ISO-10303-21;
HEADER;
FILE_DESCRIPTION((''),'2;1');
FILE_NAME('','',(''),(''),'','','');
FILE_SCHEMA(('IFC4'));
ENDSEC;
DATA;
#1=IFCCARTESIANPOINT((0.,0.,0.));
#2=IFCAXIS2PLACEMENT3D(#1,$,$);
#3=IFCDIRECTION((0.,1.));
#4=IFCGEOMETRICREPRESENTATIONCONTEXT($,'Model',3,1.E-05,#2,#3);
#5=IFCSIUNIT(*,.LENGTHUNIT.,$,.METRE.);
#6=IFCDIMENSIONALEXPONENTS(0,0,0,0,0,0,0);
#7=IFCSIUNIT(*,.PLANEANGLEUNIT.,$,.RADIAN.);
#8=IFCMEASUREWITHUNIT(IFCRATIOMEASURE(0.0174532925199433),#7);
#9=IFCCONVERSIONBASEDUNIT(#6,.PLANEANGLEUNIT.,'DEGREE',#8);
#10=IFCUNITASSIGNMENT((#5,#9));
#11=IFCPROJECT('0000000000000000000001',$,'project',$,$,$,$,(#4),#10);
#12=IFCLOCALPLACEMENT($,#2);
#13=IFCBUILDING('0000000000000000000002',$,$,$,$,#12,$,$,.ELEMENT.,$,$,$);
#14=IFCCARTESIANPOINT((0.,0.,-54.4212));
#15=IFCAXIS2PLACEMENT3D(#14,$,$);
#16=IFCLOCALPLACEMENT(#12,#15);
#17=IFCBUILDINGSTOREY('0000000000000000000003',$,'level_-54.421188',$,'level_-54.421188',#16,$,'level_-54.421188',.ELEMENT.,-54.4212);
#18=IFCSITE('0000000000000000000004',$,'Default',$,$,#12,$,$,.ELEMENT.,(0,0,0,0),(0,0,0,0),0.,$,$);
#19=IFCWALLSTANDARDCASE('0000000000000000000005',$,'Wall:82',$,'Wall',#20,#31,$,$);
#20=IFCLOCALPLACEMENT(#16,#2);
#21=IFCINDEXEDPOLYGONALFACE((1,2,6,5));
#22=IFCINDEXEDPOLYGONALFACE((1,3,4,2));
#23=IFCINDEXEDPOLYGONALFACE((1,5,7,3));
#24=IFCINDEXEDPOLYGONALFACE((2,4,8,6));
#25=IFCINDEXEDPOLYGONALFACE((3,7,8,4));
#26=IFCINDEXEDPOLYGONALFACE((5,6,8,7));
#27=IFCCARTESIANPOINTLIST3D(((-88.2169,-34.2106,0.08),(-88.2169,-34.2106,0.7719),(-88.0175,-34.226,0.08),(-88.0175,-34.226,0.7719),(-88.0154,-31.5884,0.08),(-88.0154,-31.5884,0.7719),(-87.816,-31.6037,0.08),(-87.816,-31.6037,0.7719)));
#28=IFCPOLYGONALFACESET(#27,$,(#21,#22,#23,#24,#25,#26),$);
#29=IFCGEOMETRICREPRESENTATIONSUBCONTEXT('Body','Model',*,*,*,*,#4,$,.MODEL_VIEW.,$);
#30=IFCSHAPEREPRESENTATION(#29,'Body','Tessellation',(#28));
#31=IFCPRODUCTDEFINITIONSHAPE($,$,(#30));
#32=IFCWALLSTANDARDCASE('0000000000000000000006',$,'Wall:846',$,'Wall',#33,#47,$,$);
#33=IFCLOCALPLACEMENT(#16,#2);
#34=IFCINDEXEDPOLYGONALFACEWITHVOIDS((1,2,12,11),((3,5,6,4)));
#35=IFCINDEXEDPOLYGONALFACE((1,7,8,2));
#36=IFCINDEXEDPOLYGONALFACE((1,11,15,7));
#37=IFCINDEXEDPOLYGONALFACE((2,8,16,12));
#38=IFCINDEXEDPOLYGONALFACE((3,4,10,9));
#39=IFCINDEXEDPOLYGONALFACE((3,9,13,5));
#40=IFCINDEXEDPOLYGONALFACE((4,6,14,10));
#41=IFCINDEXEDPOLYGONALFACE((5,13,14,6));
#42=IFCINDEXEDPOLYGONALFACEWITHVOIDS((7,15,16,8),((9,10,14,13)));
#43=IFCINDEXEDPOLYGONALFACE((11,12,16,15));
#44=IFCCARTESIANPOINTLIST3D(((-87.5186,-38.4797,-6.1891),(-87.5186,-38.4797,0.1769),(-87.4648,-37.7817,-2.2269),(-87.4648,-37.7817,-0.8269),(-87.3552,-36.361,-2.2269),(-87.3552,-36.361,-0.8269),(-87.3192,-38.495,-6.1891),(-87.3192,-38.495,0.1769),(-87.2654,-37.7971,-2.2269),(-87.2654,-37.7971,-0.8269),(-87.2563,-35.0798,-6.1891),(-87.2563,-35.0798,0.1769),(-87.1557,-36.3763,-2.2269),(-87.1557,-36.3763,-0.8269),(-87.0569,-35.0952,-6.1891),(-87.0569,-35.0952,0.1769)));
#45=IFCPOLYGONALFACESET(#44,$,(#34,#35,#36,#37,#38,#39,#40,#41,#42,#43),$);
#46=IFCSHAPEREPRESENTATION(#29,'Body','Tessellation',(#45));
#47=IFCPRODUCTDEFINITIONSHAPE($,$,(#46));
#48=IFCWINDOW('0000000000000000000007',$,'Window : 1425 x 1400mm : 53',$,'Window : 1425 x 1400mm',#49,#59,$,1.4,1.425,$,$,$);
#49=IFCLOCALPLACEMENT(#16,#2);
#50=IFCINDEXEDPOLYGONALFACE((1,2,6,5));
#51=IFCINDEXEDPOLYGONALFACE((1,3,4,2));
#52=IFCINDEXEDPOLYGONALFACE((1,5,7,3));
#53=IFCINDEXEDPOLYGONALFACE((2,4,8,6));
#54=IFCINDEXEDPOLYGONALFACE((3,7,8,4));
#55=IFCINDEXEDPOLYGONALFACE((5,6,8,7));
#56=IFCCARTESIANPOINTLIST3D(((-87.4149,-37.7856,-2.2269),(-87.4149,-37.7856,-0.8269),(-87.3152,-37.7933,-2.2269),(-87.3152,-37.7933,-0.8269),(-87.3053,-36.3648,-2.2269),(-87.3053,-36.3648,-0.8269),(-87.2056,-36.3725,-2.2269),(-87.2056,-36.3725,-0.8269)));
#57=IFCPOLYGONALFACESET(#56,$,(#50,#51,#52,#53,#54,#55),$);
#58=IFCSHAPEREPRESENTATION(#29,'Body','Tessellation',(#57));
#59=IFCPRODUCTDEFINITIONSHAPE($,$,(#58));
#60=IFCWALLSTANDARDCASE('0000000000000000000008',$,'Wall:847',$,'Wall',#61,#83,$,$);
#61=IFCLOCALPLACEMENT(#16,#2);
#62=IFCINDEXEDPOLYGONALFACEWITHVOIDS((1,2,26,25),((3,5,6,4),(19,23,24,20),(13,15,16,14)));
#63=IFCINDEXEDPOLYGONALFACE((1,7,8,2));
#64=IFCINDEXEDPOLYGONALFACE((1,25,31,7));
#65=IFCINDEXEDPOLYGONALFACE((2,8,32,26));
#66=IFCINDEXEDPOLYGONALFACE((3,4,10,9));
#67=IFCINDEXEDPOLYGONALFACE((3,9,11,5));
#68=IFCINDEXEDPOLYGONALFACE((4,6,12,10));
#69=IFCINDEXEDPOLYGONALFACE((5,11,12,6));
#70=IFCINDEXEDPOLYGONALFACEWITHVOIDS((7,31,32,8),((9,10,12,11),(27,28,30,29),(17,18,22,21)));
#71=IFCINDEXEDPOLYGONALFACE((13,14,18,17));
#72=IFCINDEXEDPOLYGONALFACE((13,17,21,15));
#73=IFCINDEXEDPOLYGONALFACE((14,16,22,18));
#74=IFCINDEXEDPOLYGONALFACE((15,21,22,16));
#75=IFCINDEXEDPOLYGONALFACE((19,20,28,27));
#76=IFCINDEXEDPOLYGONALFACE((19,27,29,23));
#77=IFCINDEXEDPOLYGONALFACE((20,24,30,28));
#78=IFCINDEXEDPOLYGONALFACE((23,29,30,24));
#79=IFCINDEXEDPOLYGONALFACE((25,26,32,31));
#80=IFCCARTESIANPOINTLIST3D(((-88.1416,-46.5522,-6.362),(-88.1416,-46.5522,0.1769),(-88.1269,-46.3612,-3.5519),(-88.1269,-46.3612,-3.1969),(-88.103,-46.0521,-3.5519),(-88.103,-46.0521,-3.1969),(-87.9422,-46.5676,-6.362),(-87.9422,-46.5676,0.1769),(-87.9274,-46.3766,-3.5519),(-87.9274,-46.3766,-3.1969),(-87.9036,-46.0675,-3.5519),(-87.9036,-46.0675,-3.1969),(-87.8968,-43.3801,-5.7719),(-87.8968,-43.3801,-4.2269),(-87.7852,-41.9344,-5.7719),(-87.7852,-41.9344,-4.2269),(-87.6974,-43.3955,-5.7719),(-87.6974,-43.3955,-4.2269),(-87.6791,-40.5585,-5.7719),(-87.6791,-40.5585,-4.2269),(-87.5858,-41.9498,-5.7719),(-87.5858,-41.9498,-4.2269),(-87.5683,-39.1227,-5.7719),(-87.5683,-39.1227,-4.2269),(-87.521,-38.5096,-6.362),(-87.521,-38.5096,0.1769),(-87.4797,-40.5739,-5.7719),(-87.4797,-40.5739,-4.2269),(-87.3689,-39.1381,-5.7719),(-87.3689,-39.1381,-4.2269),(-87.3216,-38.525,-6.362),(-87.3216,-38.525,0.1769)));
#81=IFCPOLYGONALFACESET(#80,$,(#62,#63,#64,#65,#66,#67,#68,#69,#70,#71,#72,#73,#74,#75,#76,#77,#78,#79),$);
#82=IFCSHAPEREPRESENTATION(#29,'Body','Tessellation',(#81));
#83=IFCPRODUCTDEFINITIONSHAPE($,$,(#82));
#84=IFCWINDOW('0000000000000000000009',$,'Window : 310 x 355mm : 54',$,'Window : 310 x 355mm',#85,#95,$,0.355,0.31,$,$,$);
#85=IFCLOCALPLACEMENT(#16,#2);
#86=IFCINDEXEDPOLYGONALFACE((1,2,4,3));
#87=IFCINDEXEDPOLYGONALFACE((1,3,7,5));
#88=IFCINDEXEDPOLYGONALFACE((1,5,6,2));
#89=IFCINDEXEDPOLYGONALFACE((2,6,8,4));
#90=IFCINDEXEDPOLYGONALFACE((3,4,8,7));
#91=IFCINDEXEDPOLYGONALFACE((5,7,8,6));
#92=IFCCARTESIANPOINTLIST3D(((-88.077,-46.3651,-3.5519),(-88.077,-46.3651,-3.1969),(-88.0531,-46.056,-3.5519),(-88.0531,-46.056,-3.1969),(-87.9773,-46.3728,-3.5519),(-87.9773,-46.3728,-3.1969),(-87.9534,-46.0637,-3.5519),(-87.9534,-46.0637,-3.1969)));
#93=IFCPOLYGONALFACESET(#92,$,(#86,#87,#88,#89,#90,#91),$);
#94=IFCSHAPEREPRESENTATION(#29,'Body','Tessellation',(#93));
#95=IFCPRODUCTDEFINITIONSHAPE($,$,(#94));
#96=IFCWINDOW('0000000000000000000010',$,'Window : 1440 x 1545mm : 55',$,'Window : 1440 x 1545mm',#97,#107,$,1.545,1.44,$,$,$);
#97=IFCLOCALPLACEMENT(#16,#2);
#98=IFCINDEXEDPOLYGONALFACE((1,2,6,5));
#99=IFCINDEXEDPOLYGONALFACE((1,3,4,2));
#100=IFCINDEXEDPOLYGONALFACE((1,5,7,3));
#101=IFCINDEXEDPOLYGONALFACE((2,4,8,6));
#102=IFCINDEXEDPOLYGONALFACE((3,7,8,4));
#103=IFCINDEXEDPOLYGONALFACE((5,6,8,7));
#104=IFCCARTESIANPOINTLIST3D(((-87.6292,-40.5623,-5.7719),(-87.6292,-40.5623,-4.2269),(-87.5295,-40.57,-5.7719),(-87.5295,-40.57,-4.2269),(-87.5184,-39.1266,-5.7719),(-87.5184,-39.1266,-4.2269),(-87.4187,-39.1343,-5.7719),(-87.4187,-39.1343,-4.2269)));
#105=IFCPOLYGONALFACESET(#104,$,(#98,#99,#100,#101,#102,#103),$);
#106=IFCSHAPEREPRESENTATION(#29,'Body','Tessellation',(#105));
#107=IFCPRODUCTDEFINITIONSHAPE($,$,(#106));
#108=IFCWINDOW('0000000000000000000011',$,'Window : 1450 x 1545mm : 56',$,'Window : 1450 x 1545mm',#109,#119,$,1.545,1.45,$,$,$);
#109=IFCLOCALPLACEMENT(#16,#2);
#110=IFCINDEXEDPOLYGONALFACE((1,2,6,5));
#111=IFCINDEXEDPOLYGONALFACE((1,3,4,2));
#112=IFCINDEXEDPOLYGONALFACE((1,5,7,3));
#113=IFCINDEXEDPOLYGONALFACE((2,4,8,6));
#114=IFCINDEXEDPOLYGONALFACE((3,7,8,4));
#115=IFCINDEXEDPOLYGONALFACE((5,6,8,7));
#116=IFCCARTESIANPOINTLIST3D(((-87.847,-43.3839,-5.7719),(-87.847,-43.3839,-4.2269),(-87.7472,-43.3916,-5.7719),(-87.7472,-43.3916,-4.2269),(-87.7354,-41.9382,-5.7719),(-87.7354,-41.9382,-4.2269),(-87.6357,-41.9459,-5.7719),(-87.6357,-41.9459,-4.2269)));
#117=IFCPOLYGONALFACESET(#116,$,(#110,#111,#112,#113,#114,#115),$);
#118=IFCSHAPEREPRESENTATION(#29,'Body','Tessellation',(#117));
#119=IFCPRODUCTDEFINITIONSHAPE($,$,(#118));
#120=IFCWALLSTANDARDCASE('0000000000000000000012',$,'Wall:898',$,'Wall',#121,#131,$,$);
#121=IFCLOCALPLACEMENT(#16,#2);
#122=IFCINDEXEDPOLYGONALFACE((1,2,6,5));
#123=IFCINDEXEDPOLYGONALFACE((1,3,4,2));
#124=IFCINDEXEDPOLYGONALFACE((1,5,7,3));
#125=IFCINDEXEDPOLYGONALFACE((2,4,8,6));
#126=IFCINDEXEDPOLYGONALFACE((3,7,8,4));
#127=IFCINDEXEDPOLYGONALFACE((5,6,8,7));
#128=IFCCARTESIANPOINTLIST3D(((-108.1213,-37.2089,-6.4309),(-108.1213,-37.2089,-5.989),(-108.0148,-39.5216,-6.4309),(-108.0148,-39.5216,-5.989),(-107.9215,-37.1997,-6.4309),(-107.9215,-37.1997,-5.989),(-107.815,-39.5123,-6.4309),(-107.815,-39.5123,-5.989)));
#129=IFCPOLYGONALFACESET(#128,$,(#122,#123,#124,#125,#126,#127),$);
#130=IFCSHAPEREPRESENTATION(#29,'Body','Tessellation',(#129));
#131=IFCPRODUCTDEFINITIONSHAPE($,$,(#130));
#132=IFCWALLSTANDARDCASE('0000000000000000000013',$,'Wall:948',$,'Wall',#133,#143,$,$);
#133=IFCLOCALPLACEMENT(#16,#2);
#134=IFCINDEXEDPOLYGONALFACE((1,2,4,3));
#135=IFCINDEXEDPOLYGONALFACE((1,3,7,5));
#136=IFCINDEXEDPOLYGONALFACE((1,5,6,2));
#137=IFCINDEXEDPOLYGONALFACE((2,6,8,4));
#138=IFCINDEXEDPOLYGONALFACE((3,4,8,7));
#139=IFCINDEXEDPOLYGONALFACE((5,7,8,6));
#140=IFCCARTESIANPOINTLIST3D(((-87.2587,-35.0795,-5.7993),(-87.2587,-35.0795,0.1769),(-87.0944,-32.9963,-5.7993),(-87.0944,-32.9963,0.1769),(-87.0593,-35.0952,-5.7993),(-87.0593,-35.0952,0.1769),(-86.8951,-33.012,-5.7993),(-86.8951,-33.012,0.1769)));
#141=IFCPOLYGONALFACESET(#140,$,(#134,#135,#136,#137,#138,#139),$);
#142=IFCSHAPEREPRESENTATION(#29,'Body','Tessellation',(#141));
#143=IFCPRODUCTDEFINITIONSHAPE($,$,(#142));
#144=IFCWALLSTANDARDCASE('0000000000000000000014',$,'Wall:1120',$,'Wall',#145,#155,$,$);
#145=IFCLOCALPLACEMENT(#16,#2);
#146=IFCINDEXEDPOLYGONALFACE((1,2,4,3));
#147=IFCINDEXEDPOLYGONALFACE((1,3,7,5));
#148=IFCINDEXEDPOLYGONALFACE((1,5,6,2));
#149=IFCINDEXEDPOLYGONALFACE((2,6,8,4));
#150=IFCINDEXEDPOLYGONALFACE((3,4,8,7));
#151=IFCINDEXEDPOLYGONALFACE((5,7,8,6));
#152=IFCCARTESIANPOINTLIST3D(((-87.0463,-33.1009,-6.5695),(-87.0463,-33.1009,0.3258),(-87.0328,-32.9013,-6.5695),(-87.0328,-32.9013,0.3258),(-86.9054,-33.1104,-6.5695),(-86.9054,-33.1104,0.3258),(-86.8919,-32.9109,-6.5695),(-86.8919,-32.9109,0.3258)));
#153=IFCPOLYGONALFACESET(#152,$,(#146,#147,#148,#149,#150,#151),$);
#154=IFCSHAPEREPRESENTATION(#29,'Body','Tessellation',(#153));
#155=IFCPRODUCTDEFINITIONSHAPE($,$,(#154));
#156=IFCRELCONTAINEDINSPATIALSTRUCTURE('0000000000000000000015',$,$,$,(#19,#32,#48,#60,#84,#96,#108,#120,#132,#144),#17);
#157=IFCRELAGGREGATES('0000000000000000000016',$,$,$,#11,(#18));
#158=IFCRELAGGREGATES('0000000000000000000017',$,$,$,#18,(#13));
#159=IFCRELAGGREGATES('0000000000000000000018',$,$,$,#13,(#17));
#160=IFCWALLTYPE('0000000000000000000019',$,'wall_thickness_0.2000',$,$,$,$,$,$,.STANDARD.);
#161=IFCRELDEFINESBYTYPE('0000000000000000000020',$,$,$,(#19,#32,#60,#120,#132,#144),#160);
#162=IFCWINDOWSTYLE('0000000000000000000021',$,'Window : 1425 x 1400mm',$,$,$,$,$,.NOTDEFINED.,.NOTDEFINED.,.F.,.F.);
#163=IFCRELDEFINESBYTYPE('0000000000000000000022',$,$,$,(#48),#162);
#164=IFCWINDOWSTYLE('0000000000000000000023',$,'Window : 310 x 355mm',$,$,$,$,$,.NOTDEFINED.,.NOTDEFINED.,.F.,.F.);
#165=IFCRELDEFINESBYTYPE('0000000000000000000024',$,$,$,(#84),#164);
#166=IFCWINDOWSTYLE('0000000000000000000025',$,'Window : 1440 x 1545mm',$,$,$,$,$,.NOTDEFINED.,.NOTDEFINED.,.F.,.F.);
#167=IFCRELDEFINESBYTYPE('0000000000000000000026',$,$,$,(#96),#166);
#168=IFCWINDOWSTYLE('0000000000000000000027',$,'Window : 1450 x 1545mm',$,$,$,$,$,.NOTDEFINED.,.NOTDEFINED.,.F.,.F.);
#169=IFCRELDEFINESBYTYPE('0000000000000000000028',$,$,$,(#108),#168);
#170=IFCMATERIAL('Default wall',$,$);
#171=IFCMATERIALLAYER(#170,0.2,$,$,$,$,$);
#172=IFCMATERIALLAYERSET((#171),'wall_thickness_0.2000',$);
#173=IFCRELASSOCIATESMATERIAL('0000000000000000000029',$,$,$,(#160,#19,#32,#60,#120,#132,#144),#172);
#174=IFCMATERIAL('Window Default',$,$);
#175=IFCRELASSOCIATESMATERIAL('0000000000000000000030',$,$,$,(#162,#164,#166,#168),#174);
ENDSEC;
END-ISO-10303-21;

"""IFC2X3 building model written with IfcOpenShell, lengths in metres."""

from ifc_helpers import new_model, entity, si_unit, converted_unit, direction, frame, frame_2d, origin, origin_2d_with_axis, place, context, subcontext, project, spatial, polyline, rectangle, outline, extrude, source, transform, mapped, material, layer, layer_set, layer_usage, type_object, type_shapes, element, fill, save


model = new_model("IFC2X3")

# Units and contexts
model_context = context("Model", 3, precision=1e-05, world=origin(), true_north=direction((0.0, 1.0)))
body_context = subcontext(model_context, "Body", "Model", "MODEL_VIEW")
ifc_project = project(units=[si_unit("LENGTHUNIT", "METRE"), converted_unit("PLANEANGLEUNIT", "DEGREE", entity("IfcRatioMeasure", 0.0174532925199433), si_unit("PLANEANGLEUNIT", "RADIAN"), dimensions=[0, 0, 0, 0, 0, 0, 0])], contexts=[model_context])

# Site, building, storey
placement_1 = place(None, origin())
site = spatial("IfcSite", under=ifc_project, at=placement_1, Name="Default", CompositionType="ELEMENT", RefLatitude=(0, 0, 0, 0), RefLongitude=(0, 0, 0, 0), RefElevation=0.0)
building = spatial("IfcBuilding", under=site, at=placement_1, CompositionType="ELEMENT")
storey_placement = place(placement_1, frame((0.0, 0.0, -54.4212)))
storey = spatial("IfcBuildingStorey", under=building, at=storey_placement, Name="level_-54.421188", ObjectType="level_-54.421188", LongName="level_-54.421188", CompositionType="ELEMENT", Elevation=-54.4212)

# Wall
ifc_material_1 = material(Name="Default wall")
ifc_layer = layer(ifc_material_1, 0.2)
ifc_layer_set = layer_set([ifc_layer], Name="wall_thickness_0.2000")
ifc_layer_usage = layer_usage(ifc_layer_set, "AXIS2", "POSITIVE", -0.1)
wall_type = type_object("IfcWallType", Name="wall_thickness_0.2000", PredefinedType="STANDARD", material=ifc_layer_set)
placement_2 = place(placement_1, frame((0.0, 0.0, -54.3412)))
wall_1_placement = place(placement_2, frame((-88.1172, -34.2183, 0.0), z_axis=(0.0, 0.0, 1.0), x_axis=(0.076622, 0.99706, 0.0)))
element("IfcWallStandardCase", 1, at=wall_1_placement, inside=storey, type_object=wall_type, material=ifc_layer_usage, Name="Wall:82", ObjectType="Wall", context=body_context, shape_type="SweptSolid", body=[
    extrude(outline(polyline([(2.63, -0.1), (2.63, 0.1), (0.0, 0.1), (0.0, -0.1), (2.63, -0.1)])), origin(), (0.0, 0.0, 1.0), 0.692),
])

# Wall, opening, window
placement_3 = place(placement_1, frame((0.0, 0.0, -60.6103)))
wall_2_placement = place(placement_3, frame((-87.1566, -35.0875, 0.0), z_axis=(0.0, 0.0, 1.0), x_axis=(-0.076939, -0.997036, 0.0)))
wall_2 = element("IfcWallStandardCase", 2, at=wall_2_placement, inside=storey, type_object=wall_type, material=ifc_layer_usage, Name="Wall:846", ObjectType="Wall", context=body_context, shape_type="SweptSolid", body=[
    extrude(outline(polyline([(3.41, -0.1), (3.41, 0.1), (0.0, 0.1), (0.0, -0.1), (3.41, -0.1)])), origin(), (0.0, 0.0, 1.0), 6.366),
])
opening_1_placement = place(wall_2_placement, frame((1.285, -0.1, 3.9622)))
opening_1 = element("IfcOpeningElement", 3, at=opening_1_placement, cuts=wall_2, ObjectType="Opening", context=body_context, shape_type="SweptSolid", body=[
    extrude(rectangle(XDim=1.425, YDim=1.4, at=frame_2d((0.7, 0.7125), x_axis=(0.0, 1.0))), frame((0.0, 0.0, 0.0), z_axis=(0.0, 1.0, 0.0), x_axis=(0.0, 0.0, 1.0)), (0.0, 0.0, 1.0), 0.2),
])
ifc_material_2 = material(Name="Window Default")
window_style_1 = type_object("IfcWindowStyle", Name="Window : 1425 x 1400mm", ConstructionType="NOTDEFINED", OperationType="NOTDEFINED", ParameterTakesPrecedence=False, Sizeable=False, material=ifc_material_2)
shared_shape_1 = source(origin(), body_context, "Body", "SweptSolid", [
    extrude(rectangle(XDim=0.1, YDim=1.425, at=origin_2d_with_axis()), frame((0.7125, 0.1, 0.0), z_axis=(0.0, 0.0, 1.0), x_axis=(0.0, 1.0, 0.0)), (0.0, 0.0, 1.0), 1.4),
])
type_shapes(window_style_1, [shared_shape_1])
window_1_placement = place(opening_1_placement, origin())
window_1 = element("IfcWindow", 4, at=window_1_placement, inside=storey, type_object=window_style_1, Name="Window : 1425 x 1400mm : 53", ObjectType="Window : 1425 x 1400mm", OverallHeight=1.4, OverallWidth=1.425, context=body_context, shape_type="MappedRepresentation", body=[
    mapped(shared_shape_1, transform((0.0, 0.0, 0.0), scale=1.0)),
])
fill(opening_1, window_1)

# Wall, openings, windows
placement_4 = place(placement_1, frame((0.0, 0.0, -60.7832)))
wall_3_placement = place(placement_4, frame((-87.4213, -38.5173, 0.0), z_axis=(0.0, 0.0, 1.0), x_axis=(-0.076939, -0.997036, 0.0)))
wall_3 = element("IfcWallStandardCase", 5, at=wall_3_placement, inside=storey, type_object=wall_type, material=ifc_layer_usage, Name="Wall:847", ObjectType="Wall", context=body_context, shape_type="SweptSolid", body=[
    extrude(outline(polyline([(8.0665, -0.1), (8.0665, 0.1), (0.0, 0.1), (0.0, -0.1), (8.0665, -0.1)])), origin(), (0.0, 0.0, 1.0), 6.5389),
])
opening_2_placement = place(wall_3_placement, frame((7.565, -0.1, 2.8101)))
opening_2 = element("IfcOpeningElement", 6, at=opening_2_placement, cuts=wall_3, ObjectType="Opening", context=body_context, shape_type="SweptSolid", body=[
    extrude(rectangle(XDim=0.31, YDim=0.355, at=frame_2d((0.1775, 0.155), x_axis=(0.0, 1.0))), frame((0.0, 0.0, 0.0), z_axis=(0.0, 1.0, 0.0), x_axis=(0.0, 0.0, 1.0)), (0.0, 0.0, 1.0), 0.2),
])
opening_3_placement = place(wall_3_placement, frame((0.615, -0.1, 0.5901)))
opening_3 = element("IfcOpeningElement", 7, at=opening_3_placement, cuts=wall_3, ObjectType="Opening", context=body_context, shape_type="SweptSolid", body=[
    extrude(rectangle(XDim=1.44, YDim=1.545, at=frame_2d((0.7725, 0.72), x_axis=(0.0, 1.0))), frame((0.0, 0.0, 0.0), z_axis=(0.0, 1.0, 0.0), x_axis=(0.0, 0.0, 1.0)), (0.0, 0.0, 1.0), 0.2),
])
opening_4_placement = place(wall_3_placement, frame((3.435, -0.1, 0.5901)))
opening_4 = element("IfcOpeningElement", 8, at=opening_4_placement, cuts=wall_3, ObjectType="Opening", context=body_context, shape_type="SweptSolid", body=[
    extrude(rectangle(XDim=1.45, YDim=1.545, at=frame_2d((0.7725, 0.725), x_axis=(0.0, 1.0))), frame((0.0, 0.0, 0.0), z_axis=(0.0, 1.0, 0.0), x_axis=(0.0, 0.0, 1.0)), (0.0, 0.0, 1.0), 0.2),
])
window_style_2 = type_object("IfcWindowStyle", Name="Window : 310 x 355mm", ConstructionType="NOTDEFINED", OperationType="NOTDEFINED", ParameterTakesPrecedence=False, Sizeable=False, material=ifc_material_2)
shared_shape_2 = source(origin(), body_context, "Body", "SweptSolid", [
    extrude(rectangle(XDim=0.1, YDim=0.31, at=origin_2d_with_axis()), frame((0.155, 0.1, 0.0), z_axis=(0.0, 0.0, 1.0), x_axis=(0.0, 1.0, 0.0)), (0.0, 0.0, 1.0), 0.355),
])
type_shapes(window_style_2, [shared_shape_2])
window_2_placement = place(opening_2_placement, origin())
window_2 = element("IfcWindow", 9, at=window_2_placement, inside=storey, type_object=window_style_2, Name="Window : 310 x 355mm : 54", ObjectType="Window : 310 x 355mm", OverallHeight=0.355, OverallWidth=0.31, context=body_context, shape_type="MappedRepresentation", body=[
    mapped(shared_shape_2, transform((0.0, 0.0, 0.0), scale=1.0)),
])
fill(opening_2, window_2)
window_style_3 = type_object("IfcWindowStyle", Name="Window : 1440 x 1545mm", ConstructionType="NOTDEFINED", OperationType="NOTDEFINED", ParameterTakesPrecedence=False, Sizeable=False, material=ifc_material_2)
shared_shape_3 = source(origin(), body_context, "Body", "SweptSolid", [
    extrude(rectangle(XDim=0.1, YDim=1.44, at=origin_2d_with_axis()), frame((0.72, 0.1, 0.0), z_axis=(0.0, 0.0, 1.0), x_axis=(0.0, 1.0, 0.0)), (0.0, 0.0, 1.0), 1.545),
])
type_shapes(window_style_3, [shared_shape_3])
window_3_placement = place(opening_3_placement, origin())
window_3 = element("IfcWindow", 10, at=window_3_placement, inside=storey, type_object=window_style_3, Name="Window : 1440 x 1545mm : 55", ObjectType="Window : 1440 x 1545mm", OverallHeight=1.545, OverallWidth=1.44, context=body_context, shape_type="MappedRepresentation", body=[
    mapped(shared_shape_3, transform((0.0, 0.0, 0.0), scale=1.0)),
])
fill(opening_3, window_3)
window_style_4 = type_object("IfcWindowStyle", Name="Window : 1450 x 1545mm", ConstructionType="NOTDEFINED", OperationType="NOTDEFINED", ParameterTakesPrecedence=False, Sizeable=False, material=ifc_material_2)
shared_shape_4 = source(origin(), body_context, "Body", "SweptSolid", [
    extrude(rectangle(XDim=0.1, YDim=1.45, at=origin_2d_with_axis()), frame((0.725, 0.1, 0.0), z_axis=(0.0, 0.0, 1.0), x_axis=(0.0, 1.0, 0.0)), (0.0, 0.0, 1.0), 1.545),
])
type_shapes(window_style_4, [shared_shape_4])
window_4_placement = place(opening_4_placement, origin())
window_4 = element("IfcWindow", 11, at=window_4_placement, inside=storey, type_object=window_style_4, Name="Window : 1450 x 1545mm : 56", ObjectType="Window : 1450 x 1545mm", OverallHeight=1.545, OverallWidth=1.45, context=body_context, shape_type="MappedRepresentation", body=[
    mapped(shared_shape_4, transform((0.0, 0.0, 0.0), scale=1.0)),
])
fill(opening_4, window_4)

# Walls
placement_5 = place(placement_1, frame((0.0, 0.0, -60.8521)))
wall_4_placement = place(placement_5, frame((-108.0214, -37.2043, 0.0), z_axis=(0.0, 0.0, 1.0), x_axis=(0.046015, -0.998941, 0.0)))
element("IfcWallStandardCase", 12, at=wall_4_placement, inside=storey, type_object=wall_type, material=ifc_layer_usage, Name="Wall:898", ObjectType="Wall", context=body_context, shape_type="SweptSolid", body=[
    extrude(outline(polyline([(2.3151, -0.1), (2.3151, 0.1), (0.0, 0.1), (0.0, -0.1), (2.3151, -0.1)])), origin(), (0.0, 0.0, 1.0), 0.4419),
])
placement_6 = place(placement_1, frame((0.0, 0.0, -60.2205)))
wall_5_placement = place(placement_6, frame((-86.9948, -33.0041, 0.0), z_axis=(0.0, 0.0, 1.0), x_axis=(-0.078608, -0.996906, 0.0)))
element("IfcWallStandardCase", 13, at=wall_5_placement, inside=storey, type_object=wall_type, material=ifc_layer_usage, Name="Wall:948", ObjectType="Wall", context=body_context, shape_type="SweptSolid", body=[
    extrude(outline(polyline([(2.0897, -0.1), (2.0897, 0.1), (0.0, 0.1), (0.0, -0.1), (2.0897, -0.1)])), origin(), (0.0, 0.0, 1.0), 5.9762),
])
placement_7 = place(placement_1, frame((0.0, 0.0, -60.9907)))
wall_6_placement = place(placement_7, frame((-86.8987, -33.0106, 0.0), z_axis=(0.0, 0.0, 1.0), x_axis=(-0.997729, 0.067353, 0.0)))
element("IfcWallStandardCase", 14, at=wall_6_placement, inside=storey, type_object=wall_type, material=ifc_layer_usage, Name="Wall:1120", ObjectType="Wall", context=body_context, shape_type="SweptSolid", body=[
    extrude(outline(polyline([(0.1412, -0.1), (0.1412, 0.1), (0.0, 0.1), (0.0, -0.1), (0.1412, -0.1)])), origin(), (0.0, 0.0, 1.0), 6.8953),
])

save(model, "model.ifc")
